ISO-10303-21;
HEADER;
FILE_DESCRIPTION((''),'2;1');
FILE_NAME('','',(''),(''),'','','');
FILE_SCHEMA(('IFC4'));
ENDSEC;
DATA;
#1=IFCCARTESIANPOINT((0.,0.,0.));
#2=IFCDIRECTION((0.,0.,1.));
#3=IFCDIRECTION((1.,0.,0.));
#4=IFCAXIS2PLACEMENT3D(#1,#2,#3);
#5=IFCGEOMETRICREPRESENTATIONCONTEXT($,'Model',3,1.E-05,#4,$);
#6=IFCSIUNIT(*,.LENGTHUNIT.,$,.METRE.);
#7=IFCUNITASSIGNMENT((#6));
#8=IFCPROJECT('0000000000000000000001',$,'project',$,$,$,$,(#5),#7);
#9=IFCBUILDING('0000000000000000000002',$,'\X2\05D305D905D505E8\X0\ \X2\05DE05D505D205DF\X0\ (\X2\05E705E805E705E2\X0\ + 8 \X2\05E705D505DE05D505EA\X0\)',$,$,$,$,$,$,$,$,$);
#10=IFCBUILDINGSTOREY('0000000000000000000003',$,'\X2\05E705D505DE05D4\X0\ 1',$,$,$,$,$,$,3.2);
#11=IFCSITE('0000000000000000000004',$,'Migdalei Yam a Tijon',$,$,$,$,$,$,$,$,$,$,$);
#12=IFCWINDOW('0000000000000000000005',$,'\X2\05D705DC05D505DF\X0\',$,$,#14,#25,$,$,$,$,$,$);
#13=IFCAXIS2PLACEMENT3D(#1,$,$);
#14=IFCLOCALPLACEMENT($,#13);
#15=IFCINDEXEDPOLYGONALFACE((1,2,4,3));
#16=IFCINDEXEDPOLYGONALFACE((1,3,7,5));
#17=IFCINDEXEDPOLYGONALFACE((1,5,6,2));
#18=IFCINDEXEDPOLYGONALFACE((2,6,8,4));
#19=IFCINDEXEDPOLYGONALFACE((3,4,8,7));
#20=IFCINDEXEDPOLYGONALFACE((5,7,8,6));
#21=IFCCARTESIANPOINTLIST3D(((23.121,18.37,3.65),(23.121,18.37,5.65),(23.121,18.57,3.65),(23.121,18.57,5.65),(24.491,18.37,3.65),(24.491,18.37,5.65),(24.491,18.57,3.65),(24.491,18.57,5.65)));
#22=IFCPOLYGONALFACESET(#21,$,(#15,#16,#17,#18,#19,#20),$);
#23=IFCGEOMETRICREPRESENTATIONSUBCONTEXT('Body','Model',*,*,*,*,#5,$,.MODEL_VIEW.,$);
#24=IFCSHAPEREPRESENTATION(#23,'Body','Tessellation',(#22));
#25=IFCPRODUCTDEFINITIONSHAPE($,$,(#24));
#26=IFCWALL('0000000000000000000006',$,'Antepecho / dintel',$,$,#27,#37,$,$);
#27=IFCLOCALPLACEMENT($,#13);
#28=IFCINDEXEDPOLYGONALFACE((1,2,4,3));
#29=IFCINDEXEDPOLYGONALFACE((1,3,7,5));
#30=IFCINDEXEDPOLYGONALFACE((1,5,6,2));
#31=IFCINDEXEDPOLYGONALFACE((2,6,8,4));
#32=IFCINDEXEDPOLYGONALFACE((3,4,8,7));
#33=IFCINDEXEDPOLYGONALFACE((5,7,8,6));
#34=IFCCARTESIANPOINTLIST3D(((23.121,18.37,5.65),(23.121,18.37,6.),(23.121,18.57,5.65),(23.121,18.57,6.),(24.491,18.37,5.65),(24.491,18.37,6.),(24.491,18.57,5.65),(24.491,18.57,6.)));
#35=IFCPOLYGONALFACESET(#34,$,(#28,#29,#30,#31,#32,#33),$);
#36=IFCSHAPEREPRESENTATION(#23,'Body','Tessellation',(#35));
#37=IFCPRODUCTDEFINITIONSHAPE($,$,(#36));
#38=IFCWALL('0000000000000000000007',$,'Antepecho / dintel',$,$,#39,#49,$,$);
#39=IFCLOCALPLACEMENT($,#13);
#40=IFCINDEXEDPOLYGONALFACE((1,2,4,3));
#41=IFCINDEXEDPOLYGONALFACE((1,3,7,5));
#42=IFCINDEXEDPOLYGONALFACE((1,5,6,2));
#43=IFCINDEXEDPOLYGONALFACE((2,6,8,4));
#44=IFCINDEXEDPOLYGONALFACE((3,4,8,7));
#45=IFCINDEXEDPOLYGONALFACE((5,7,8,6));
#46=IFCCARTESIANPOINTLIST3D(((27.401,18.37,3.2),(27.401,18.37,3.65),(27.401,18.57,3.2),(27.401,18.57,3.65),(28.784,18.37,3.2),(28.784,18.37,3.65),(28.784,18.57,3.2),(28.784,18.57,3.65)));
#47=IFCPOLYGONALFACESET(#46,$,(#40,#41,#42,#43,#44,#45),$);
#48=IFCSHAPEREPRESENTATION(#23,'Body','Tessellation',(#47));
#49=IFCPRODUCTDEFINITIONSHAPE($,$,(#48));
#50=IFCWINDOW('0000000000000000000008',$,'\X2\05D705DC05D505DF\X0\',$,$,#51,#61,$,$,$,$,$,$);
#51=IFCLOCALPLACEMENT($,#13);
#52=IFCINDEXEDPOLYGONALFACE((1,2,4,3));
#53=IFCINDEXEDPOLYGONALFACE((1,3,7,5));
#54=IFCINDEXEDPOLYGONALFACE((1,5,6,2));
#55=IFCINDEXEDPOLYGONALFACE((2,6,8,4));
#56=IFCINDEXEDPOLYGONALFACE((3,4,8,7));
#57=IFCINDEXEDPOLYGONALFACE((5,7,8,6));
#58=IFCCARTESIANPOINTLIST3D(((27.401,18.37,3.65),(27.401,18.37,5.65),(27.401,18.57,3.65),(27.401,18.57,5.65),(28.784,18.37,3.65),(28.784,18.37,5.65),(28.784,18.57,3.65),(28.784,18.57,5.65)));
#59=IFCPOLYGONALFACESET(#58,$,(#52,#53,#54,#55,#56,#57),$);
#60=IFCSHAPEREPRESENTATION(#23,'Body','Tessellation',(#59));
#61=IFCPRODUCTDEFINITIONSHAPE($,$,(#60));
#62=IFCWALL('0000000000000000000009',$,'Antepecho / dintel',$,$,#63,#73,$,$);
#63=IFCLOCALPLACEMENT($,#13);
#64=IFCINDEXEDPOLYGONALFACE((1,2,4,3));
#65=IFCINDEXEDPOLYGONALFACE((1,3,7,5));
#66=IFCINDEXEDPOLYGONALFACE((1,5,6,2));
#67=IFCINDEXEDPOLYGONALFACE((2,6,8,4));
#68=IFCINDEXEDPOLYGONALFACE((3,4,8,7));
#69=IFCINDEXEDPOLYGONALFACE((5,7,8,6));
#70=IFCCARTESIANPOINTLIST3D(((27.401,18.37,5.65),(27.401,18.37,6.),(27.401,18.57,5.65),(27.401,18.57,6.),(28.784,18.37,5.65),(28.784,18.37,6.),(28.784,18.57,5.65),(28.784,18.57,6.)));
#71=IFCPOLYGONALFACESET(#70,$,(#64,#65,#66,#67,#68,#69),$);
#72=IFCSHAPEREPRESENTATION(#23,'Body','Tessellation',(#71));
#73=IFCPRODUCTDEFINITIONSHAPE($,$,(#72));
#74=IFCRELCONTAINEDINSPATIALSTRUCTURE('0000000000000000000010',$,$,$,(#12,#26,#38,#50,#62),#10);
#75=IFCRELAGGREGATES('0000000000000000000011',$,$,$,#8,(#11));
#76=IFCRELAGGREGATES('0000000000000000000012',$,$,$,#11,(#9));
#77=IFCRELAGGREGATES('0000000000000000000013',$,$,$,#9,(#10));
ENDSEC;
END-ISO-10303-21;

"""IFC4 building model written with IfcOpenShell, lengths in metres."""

from ifc_helpers import new_model, si_unit, frame, origin_with_axes, context, subcontext, project, spatial, line, indexed_curve, outline, extrude, element, save


model = new_model("IFC4")

# Units and contexts
model_context = context("Model", 3, precision=1e-05, world=origin_with_axes())
body_context = subcontext(model_context, "Body", "Model", "MODEL_VIEW")
ifc_project = project(units=[si_unit("LENGTHUNIT", "METRE")], contexts=[model_context])

# Site, building, storey
site = spatial("IfcSite", under=ifc_project, Name="Migdalei Yam a Tijon")
building = spatial("IfcBuilding", under=site, Name="דיור מוגן (קרקע + 8 קומות)")
storey = spatial("IfcBuildingStorey", under=building, Name="קומה 1", Elevation=3.2)

# Window
element("IfcWindow", 1, inside=storey, Name="חלון", context=body_context, shape_type="SweptSolid", body=[
    extrude(outline(indexed_curve([(0.0, 0.0), (1.37, 0.0), (1.37, 0.2), (0.0, 0.2)], segments=[line(1, 2, 3, 4, 1)])), frame((23.121, 18.37, 3.65), z_axis=(0.0, 0.0, 1.0), x_axis=(1.0, 0.0, 0.0)), (0.0, 0.0, 1.0), 2.0),
])

# Walls
element("IfcWall", 2, inside=storey, Name="Antepecho / dintel", context=body_context, shape_type="SweptSolid", body=[
    extrude(outline(indexed_curve([(0.0, 0.0), (1.37, 0.0), (1.37, 0.2), (0.0, 0.2)], segments=[line(1, 2, 3, 4, 1)])), frame((23.121, 18.37, 5.65), z_axis=(0.0, 0.0, 1.0), x_axis=(1.0, 0.0, 0.0)), (0.0, 0.0, 1.0), 0.35),
])
element("IfcWall", 3, inside=storey, Name="Antepecho / dintel", context=body_context, shape_type="SweptSolid", body=[
    extrude(outline(indexed_curve([(0.0, 0.0), (1.383, 0.0), (1.383, 0.2), (0.0, 0.2)], segments=[line(1, 2, 3, 4, 1)])), frame((27.401, 18.37, 3.2), z_axis=(0.0, 0.0, 1.0), x_axis=(1.0, 0.0, 0.0)), (0.0, 0.0, 1.0), 0.45),
])

# Window
element("IfcWindow", 4, inside=storey, Name="חלון", context=body_context, shape_type="SweptSolid", body=[
    extrude(outline(indexed_curve([(0.0, 0.0), (1.383, 0.0), (1.383, 0.2), (0.0, 0.2)], segments=[line(1, 2, 3, 4, 1)])), frame((27.401, 18.37, 3.65), z_axis=(0.0, 0.0, 1.0), x_axis=(1.0, 0.0, 0.0)), (0.0, 0.0, 1.0), 2.0),
])

# Wall
element("IfcWall", 5, inside=storey, Name="Antepecho / dintel", context=body_context, shape_type="SweptSolid", body=[
    extrude(outline(indexed_curve([(0.0, 0.0), (1.383, 0.0), (1.383, 0.2), (0.0, 0.2)], segments=[line(1, 2, 3, 4, 1)])), frame((27.401, 18.37, 5.65), z_axis=(0.0, 0.0, 1.0), x_axis=(1.0, 0.0, 0.0)), (0.0, 0.0, 1.0), 0.35),
])

save(model, "model.ifc")
